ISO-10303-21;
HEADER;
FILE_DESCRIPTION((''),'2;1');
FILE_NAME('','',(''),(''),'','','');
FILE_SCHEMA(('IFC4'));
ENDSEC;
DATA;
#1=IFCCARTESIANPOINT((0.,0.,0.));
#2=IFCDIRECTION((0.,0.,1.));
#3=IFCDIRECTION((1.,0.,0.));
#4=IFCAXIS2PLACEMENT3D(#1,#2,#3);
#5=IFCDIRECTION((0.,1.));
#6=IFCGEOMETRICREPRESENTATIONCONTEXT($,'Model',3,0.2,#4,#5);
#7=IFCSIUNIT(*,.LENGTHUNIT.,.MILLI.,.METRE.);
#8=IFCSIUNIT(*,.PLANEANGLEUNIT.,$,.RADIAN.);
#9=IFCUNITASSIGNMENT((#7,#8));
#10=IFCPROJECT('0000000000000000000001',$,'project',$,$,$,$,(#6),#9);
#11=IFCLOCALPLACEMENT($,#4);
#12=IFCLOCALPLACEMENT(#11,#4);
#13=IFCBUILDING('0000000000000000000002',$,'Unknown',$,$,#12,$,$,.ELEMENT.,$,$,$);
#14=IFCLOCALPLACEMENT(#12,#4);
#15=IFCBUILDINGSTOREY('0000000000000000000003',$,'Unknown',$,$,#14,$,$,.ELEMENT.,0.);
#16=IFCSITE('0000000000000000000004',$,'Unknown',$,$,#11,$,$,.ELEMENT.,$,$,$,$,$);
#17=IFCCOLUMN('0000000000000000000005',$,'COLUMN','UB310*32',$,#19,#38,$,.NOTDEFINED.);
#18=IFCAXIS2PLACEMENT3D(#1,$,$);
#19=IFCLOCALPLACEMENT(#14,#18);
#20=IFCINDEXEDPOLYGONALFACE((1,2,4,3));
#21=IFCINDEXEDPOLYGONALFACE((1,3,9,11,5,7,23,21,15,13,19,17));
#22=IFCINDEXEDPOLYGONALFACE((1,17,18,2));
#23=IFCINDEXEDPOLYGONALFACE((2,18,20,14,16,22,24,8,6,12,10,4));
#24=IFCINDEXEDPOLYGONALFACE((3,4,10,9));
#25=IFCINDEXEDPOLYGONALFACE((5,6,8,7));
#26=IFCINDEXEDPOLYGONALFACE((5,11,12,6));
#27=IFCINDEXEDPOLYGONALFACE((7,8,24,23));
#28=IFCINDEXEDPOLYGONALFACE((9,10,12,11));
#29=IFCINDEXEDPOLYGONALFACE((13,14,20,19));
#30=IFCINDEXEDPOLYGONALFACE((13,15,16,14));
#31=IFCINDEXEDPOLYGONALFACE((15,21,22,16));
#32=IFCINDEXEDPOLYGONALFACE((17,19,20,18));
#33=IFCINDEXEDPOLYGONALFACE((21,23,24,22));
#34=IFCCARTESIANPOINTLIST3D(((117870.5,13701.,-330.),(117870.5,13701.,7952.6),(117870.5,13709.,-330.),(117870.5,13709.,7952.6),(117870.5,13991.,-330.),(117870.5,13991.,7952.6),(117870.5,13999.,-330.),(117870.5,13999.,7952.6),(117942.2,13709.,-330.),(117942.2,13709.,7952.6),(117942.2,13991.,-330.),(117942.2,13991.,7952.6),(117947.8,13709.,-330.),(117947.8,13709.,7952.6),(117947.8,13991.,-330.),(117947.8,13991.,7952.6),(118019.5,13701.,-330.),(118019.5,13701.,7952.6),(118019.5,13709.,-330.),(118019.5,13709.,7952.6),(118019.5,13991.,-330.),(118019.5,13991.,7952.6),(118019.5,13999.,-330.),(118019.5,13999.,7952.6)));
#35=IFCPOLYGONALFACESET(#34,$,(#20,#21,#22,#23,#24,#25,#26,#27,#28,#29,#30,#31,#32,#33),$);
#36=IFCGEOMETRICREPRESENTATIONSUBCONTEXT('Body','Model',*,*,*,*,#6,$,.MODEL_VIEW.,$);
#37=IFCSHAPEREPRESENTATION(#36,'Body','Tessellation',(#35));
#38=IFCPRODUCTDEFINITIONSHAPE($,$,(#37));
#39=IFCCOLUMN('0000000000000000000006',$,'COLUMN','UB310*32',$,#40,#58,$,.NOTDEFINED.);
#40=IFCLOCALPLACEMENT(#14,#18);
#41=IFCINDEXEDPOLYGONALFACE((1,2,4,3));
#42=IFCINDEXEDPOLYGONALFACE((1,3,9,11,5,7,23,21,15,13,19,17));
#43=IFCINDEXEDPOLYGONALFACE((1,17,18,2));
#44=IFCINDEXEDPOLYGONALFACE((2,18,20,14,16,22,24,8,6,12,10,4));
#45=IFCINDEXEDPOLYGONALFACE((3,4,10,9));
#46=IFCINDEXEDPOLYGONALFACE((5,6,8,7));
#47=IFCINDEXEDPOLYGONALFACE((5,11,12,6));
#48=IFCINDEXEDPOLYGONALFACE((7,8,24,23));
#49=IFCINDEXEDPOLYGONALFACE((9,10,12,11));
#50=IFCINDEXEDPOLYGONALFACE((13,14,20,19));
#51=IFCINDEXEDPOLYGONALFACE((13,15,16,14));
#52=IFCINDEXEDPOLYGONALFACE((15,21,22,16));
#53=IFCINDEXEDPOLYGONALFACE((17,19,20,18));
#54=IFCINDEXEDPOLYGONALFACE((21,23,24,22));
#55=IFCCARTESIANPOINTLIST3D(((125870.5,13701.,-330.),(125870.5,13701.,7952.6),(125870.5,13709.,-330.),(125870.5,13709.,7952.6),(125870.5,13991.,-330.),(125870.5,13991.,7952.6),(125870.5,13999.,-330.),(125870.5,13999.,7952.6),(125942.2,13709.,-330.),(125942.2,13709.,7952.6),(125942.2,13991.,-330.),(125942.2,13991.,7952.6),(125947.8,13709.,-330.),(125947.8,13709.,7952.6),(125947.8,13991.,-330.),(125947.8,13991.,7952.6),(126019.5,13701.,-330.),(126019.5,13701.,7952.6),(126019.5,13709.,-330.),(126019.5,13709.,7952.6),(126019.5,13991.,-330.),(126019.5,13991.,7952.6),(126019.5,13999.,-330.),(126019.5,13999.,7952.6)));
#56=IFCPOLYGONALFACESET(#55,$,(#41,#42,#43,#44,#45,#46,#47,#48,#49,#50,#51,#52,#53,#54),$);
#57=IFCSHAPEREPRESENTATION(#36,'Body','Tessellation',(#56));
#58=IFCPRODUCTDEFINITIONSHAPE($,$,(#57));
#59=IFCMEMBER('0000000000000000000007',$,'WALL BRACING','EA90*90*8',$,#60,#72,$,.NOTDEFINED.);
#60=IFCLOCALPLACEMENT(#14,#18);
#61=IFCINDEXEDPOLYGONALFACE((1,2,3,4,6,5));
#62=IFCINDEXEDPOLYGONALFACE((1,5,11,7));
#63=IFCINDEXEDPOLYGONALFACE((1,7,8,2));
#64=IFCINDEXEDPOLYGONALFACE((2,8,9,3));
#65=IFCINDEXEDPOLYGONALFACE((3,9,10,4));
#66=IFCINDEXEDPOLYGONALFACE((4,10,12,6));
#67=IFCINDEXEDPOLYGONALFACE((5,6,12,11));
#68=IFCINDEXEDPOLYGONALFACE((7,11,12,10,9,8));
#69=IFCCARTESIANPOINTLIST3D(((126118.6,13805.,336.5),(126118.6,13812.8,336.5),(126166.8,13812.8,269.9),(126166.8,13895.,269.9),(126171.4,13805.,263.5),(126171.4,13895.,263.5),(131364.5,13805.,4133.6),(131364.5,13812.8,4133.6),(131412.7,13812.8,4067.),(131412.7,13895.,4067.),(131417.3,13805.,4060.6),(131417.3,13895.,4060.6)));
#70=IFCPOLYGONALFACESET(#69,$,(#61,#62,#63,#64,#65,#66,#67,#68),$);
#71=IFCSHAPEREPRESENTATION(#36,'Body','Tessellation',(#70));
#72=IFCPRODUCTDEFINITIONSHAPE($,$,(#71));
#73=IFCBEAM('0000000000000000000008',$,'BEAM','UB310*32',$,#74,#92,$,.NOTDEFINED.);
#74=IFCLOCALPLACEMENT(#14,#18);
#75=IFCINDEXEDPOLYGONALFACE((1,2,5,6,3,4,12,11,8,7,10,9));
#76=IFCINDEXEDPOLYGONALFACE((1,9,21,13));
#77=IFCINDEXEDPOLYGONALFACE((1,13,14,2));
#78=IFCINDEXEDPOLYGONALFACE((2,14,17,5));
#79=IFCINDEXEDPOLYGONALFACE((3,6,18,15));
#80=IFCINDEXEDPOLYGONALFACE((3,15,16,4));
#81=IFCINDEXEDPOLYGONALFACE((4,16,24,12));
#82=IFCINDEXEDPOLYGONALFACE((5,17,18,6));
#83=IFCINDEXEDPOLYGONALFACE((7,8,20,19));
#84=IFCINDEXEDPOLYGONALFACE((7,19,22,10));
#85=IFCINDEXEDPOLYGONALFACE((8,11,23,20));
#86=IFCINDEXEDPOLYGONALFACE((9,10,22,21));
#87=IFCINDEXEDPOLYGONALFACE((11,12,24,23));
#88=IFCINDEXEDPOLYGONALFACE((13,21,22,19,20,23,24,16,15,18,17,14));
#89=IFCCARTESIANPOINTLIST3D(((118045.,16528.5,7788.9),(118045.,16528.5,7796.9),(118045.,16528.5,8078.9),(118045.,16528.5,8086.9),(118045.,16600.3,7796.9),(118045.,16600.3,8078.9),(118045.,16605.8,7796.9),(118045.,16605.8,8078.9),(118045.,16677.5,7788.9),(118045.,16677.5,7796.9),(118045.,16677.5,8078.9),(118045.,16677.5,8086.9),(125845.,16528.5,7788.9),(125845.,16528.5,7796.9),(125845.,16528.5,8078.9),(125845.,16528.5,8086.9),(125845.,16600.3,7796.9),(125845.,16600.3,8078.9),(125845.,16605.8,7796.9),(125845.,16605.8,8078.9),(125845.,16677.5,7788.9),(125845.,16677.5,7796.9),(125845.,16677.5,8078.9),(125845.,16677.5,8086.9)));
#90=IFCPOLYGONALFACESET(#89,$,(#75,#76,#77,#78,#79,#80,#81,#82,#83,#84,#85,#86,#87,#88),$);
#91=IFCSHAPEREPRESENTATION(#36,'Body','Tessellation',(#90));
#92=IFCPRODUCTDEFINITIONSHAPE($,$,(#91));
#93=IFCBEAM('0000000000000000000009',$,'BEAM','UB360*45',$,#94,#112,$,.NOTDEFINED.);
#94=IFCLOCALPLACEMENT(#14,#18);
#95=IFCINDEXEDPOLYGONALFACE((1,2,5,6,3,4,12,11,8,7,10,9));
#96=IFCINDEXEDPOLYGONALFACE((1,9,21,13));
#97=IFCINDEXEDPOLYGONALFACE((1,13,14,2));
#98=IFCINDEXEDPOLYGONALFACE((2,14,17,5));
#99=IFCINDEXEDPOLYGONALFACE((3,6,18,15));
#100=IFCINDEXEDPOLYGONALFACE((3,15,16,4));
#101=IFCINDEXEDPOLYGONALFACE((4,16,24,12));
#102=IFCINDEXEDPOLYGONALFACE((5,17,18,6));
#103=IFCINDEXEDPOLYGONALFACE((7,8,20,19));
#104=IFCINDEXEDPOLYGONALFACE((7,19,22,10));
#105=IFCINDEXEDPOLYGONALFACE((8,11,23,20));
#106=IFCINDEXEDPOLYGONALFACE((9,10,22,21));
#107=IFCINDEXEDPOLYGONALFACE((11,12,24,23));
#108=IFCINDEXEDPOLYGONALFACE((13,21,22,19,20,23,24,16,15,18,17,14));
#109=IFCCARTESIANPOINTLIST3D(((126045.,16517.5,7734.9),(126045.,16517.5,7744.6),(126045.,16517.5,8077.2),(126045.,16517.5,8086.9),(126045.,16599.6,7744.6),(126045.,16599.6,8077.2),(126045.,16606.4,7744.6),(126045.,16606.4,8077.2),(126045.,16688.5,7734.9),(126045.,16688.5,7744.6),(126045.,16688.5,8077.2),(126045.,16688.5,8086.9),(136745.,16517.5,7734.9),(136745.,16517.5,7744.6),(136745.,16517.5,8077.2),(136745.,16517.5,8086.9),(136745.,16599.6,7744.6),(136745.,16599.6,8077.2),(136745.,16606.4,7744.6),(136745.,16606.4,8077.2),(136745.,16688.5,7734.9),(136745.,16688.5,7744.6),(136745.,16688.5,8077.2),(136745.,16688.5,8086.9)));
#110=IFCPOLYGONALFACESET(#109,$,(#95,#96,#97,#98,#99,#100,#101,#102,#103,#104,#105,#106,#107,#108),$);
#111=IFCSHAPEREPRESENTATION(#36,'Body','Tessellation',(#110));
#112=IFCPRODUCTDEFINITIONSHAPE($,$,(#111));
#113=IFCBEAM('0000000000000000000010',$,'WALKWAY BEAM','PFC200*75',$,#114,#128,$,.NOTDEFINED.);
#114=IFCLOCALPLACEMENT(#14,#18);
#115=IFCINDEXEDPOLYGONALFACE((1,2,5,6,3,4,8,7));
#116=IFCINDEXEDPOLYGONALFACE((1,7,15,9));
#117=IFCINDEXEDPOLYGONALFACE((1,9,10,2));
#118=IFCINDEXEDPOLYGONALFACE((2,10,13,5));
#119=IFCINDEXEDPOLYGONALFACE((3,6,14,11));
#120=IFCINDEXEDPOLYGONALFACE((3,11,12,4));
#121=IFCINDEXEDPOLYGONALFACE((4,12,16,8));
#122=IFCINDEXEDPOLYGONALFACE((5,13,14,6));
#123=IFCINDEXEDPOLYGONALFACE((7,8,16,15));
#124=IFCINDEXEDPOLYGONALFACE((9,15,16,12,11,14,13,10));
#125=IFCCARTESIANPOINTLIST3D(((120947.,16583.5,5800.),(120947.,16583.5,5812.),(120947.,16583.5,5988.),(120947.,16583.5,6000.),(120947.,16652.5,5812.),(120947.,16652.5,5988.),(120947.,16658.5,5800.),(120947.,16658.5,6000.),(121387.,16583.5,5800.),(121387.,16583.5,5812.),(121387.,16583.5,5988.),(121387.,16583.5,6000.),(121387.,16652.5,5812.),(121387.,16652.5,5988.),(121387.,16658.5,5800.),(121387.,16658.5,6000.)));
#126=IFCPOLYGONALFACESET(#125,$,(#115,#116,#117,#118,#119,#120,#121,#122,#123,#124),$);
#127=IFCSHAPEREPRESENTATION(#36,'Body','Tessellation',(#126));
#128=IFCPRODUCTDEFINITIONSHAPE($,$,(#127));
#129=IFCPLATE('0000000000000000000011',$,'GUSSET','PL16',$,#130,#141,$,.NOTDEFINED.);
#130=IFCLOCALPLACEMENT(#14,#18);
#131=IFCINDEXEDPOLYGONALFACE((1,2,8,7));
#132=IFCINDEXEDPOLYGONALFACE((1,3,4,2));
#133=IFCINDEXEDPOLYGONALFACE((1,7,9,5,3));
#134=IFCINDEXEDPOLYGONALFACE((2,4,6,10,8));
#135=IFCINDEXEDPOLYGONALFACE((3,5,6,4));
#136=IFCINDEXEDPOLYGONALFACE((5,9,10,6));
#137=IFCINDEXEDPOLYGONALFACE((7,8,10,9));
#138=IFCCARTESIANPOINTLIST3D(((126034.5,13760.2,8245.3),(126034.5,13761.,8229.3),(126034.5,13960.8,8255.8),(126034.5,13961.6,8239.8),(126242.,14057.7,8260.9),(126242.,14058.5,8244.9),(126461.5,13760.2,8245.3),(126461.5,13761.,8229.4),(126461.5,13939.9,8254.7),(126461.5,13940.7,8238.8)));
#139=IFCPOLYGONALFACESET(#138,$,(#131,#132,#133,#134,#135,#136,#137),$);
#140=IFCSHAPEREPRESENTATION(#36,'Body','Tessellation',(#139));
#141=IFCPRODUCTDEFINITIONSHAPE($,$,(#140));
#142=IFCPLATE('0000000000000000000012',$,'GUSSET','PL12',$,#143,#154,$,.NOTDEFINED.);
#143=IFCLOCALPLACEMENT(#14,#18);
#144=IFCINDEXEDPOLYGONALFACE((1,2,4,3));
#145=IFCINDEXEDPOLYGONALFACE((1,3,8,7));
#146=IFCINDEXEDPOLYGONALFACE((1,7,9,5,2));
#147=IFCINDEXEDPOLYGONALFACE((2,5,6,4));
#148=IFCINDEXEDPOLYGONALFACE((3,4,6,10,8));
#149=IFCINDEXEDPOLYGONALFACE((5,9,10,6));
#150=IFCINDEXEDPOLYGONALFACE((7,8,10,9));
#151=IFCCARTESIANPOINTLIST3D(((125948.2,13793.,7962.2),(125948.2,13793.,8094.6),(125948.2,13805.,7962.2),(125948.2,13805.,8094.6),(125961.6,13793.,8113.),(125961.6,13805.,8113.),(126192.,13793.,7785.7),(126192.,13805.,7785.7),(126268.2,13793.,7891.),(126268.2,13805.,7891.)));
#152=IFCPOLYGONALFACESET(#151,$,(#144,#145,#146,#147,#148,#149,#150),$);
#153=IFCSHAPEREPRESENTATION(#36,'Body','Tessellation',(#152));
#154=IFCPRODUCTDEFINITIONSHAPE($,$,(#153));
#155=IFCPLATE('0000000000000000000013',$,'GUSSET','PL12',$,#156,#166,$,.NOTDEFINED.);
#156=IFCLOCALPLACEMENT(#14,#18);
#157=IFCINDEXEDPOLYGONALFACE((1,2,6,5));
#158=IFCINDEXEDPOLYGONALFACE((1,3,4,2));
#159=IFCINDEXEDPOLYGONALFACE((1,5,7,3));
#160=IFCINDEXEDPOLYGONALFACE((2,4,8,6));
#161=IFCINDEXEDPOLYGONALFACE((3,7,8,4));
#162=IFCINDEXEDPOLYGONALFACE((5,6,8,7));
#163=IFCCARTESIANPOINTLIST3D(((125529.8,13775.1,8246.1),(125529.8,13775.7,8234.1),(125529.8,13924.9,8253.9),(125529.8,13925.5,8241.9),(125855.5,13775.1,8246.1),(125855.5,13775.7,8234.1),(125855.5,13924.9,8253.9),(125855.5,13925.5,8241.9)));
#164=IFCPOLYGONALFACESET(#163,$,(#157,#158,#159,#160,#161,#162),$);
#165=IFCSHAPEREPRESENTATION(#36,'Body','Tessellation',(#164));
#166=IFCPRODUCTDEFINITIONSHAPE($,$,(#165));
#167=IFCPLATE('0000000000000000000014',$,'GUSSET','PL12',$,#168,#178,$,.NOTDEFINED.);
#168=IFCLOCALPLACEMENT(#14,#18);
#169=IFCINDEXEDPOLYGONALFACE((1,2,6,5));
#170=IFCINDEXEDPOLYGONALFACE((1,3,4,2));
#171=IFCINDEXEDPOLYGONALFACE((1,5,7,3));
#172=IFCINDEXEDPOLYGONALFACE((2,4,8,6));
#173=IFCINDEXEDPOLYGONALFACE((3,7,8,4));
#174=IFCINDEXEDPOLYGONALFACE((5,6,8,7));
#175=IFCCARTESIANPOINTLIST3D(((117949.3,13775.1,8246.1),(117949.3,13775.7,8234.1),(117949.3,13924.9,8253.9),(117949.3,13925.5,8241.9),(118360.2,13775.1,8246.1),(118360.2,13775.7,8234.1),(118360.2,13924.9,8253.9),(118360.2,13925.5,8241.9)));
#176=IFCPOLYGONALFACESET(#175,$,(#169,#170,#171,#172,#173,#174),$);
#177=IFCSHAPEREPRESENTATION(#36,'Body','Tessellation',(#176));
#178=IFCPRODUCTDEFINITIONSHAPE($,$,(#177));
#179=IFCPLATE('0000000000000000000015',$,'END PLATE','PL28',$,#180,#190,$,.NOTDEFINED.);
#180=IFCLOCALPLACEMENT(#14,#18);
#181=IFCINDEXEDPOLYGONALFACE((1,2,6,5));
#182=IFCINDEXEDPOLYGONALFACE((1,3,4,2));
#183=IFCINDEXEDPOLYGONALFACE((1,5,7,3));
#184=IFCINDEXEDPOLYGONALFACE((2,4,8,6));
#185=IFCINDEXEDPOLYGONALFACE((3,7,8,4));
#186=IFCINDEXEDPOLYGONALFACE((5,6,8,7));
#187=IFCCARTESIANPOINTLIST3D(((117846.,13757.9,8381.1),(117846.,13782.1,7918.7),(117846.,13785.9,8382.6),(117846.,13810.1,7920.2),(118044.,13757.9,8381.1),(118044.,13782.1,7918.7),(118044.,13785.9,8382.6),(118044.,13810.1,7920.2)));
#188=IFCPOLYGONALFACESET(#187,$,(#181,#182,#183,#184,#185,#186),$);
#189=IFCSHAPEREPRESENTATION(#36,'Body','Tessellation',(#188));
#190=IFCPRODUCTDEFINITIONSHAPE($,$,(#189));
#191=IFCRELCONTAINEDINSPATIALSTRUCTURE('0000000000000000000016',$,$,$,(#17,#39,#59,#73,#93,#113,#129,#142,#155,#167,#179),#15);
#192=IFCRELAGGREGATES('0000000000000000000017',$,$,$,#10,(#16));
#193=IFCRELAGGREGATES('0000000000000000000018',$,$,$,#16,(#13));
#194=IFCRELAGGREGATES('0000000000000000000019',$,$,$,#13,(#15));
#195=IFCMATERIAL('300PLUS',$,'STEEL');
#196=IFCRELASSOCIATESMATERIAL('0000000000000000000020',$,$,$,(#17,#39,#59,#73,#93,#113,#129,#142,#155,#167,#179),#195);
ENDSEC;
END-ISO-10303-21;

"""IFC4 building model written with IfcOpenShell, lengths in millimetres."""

from ifc_helpers import new_model, si_unit, direction, frame, origin_with_axes, place, context, subcontext, project, spatial, line, indexed_curve, outline, extrude, material, element, save


model = new_model("IFC4")

# Units and contexts
model_context = context("Model", 3, precision=0.2, world=origin_with_axes(), true_north=direction((0.0, 1.0)))
body_context = subcontext(model_context, "Body", "Model", "MODEL_VIEW")
ifc_project = project(units=[si_unit("LENGTHUNIT", "METRE", prefix="MILLI"), si_unit("PLANEANGLEUNIT", "RADIAN")], contexts=[model_context])

# Site, building, storey
site_placement = place(None, origin_with_axes())
site = spatial("IfcSite", under=ifc_project, at=site_placement, Name="Unknown", CompositionType="ELEMENT")
building_placement = place(site_placement, origin_with_axes())
building = spatial("IfcBuilding", under=site, at=building_placement, Name="Unknown", CompositionType="ELEMENT")
storey_placement = place(building_placement, origin_with_axes())
storey = spatial("IfcBuildingStorey", under=building, at=storey_placement, Name="Unknown", CompositionType="ELEMENT", Elevation=0.0)

# Columns
ifc_material_1 = material(Name="300PLUS", Category="STEEL")
for number, where, z_axis, x_axis, name in (
    (1, (117945.0, 13850.0, -330.0), (-1.0, 0.0, 0.0), (0.0, 0.0, 1.0), "COLUMN"),
    (2, (125945.0, 13850.0, -330.0), (-1.0, 0.0, 0.0), (0.0, 0.0, 1.0), "COLUMN"),
):
    element("IfcColumn", number, at=place(storey_placement, frame(where, z_axis=z_axis, x_axis=x_axis)), inside=storey, material=ifc_material_1, Name=name, Description="UB310*32", PredefinedType="NOTDEFINED", context=body_context, shape_type="SolidModel", body=[
        extrude(outline(indexed_curve([(-74.5, -149.0), (74.5, -149.0), (74.5, -141.0), (2.8, -141.0), (2.8, 141.0), (74.5, 141.0), (74.5, 149.0), (-74.5, 149.0), (-74.5, 141.0), (-2.8, 141.0), (-2.8, -141.0), (-74.5, -141.0)], segments=[line(1, 2, 3, 4, 5, 6, 7, 8, 9, 10, 11, 12, 1)])), frame((0.0, 0.0, 0.0), z_axis=(-1.0, 0.0, 0.0), x_axis=(0.0, 0.0, 1.0)), (0.0, 0.0, -1.0), 8282.6),
    ])

# Member
member_placement = place(storey_placement, frame((126145.0, 13850.0, 300.0), z_axis=(-0.586342, 0.0, 0.810064), x_axis=(0.810064, 0.0, 0.586342)))
element("IfcMember", 3, at=member_placement, inside=storey, material=ifc_material_1, Name="WALL BRACING", Description="EA90*90*8", PredefinedType="NOTDEFINED", context=body_context, shape_type="SolidModel", body=[
    extrude(outline(indexed_curve([(-45.0, -45.0), (45.0, -45.0), (45.0, -37.2), (-37.2, -37.2), (-37.2, 45.0), (-45.0, 45.0)], segments=[line(1, 2, 3, 4, 5, 6, 1)])), frame((0.0, 0.0, 0.0), z_axis=(-1.0, 0.0, 0.0), x_axis=(0.0, 0.0, 1.0)), (0.0, 0.0, -1.0), 6475.9),
])

# Beams
beam_1_placement = place(storey_placement, frame((118045.0, 16603.0, 7937.9), z_axis=(0.0, -1.0, 0.0), x_axis=(1.0, 0.0, 0.0)))
element("IfcBeam", 4, at=beam_1_placement, inside=storey, material=ifc_material_1, Name="BEAM", Description="UB310*32", PredefinedType="NOTDEFINED", context=body_context, shape_type="SolidModel", body=[
    extrude(outline(indexed_curve([(-74.5, -149.0), (74.5, -149.0), (74.5, -141.0), (2.8, -141.0), (2.8, 141.0), (74.5, 141.0), (74.5, 149.0), (-74.5, 149.0), (-74.5, 141.0), (-2.8, 141.0), (-2.8, -141.0), (-74.5, -141.0)], segments=[line(1, 2, 3, 4, 5, 6, 7, 8, 9, 10, 11, 12, 1)])), frame((0.0, 0.0, 0.0), z_axis=(-1.0, 0.0, 0.0), x_axis=(0.0, 0.0, 1.0)), (0.0, 0.0, -1.0), 7800.0),
])
beam_2_placement = place(storey_placement, frame((126045.0, 16603.0, 7910.9), z_axis=(0.0, -1.0, 0.0), x_axis=(1.0, 0.0, 0.0)))
element("IfcBeam", 5, at=beam_2_placement, inside=storey, material=ifc_material_1, Name="BEAM", Description="UB360*45", PredefinedType="NOTDEFINED", context=body_context, shape_type="SolidModel", body=[
    extrude(outline(indexed_curve([(-85.5, -176.0), (85.5, -176.0), (85.5, -166.3), (3.5, -166.3), (3.5, 166.3), (85.5, 166.3), (85.5, 176.0), (-85.5, 176.0), (-85.5, 166.3), (-3.5, 166.3), (-3.5, -166.3), (-85.5, -166.3)], segments=[line(1, 2, 3, 4, 5, 6, 7, 8, 9, 10, 11, 12, 1)])), frame((0.0, 0.0, 0.0), z_axis=(-1.0, 0.0, 0.0), x_axis=(0.0, 0.0, 1.0)), (0.0, 0.0, -1.0), 10700.0),
])
beam_3_placement = place(storey_placement, frame((120947.0, 16621.0, 5900.0), z_axis=(0.0, -1.0, 0.0), x_axis=(1.0, 0.0, 0.0)))
element("IfcBeam", 6, at=beam_3_placement, inside=storey, material=ifc_material_1, Name="WALKWAY BEAM", Description="PFC200*75", PredefinedType="NOTDEFINED", context=body_context, shape_type="SolidModel", body=[
    extrude(outline(indexed_curve([(-37.5, -100.0), (37.5, -100.0), (37.5, -88.0), (-31.5, -88.0), (-31.5, 88.0), (37.5, 88.0), (37.5, 100.0), (-37.5, 100.0)], segments=[line(1, 2, 3, 4, 5, 6, 7, 8, 1)])), frame((0.0, 0.0, 0.0), z_axis=(-1.0, 0.0, 0.0), x_axis=(0.0, 0.0, 1.0)), (0.0, 0.0, -1.0), 440.0),
])

# Plates
plate_1_placement = place(storey_placement, frame((126034.5, 13961.2, 8247.8), z_axis=(-0.000135, -0.052271, 0.998633), x_axis=(0.0, -0.998633, -0.052271)))
element("IfcPlate", 7, at=plate_1_placement, inside=storey, material=ifc_material_1, Name="GUSSET", Description="PL16", PredefinedType="NOTDEFINED", context=body_context, shape_type="SolidModel", body=[
    extrude(outline(indexed_curve([(0.0, 0.0), (200.9, 0.0), (200.9, 427.0), (20.9, 427.0), (-97.0, 207.5)], segments=[line(1, 2, 3, 4, 5, 1)])), frame((0.0, 0.0, 8.0), z_axis=(0.0, 0.0, 1.0), x_axis=(1.0, 0.0, 0.0)), (0.0, 0.0, -1.0), 16.0),
])
plate_2_placement = place(storey_placement, frame((125948.2, 13799.0, 8094.6), z_axis=(0.0, -1.0, 0.0), x_axis=(0.0, 0.0, -1.0)))
element("IfcPlate", 8, at=plate_2_placement, inside=storey, material=ifc_material_1, Name="GUSSET", Description="PL12", PredefinedType="NOTDEFINED", context=body_context, shape_type="SolidModel", body=[
    extrude(outline(indexed_curve([(0.0, 0.0), (132.4, 0.0), (308.9, 243.8), (203.6, 320.0), (-18.4, 13.4)], segments=[line(1, 2, 3, 4, 5, 1)])), frame((0.0, 0.0, 6.0), z_axis=(0.0, 0.0, 1.0), x_axis=(1.0, 0.0, 0.0)), (0.0, 0.0, -1.0), 12.0),
])
plate_3_placement = place(storey_placement, frame((125855.5, 13925.2, 8247.9), z_axis=(0.0, -0.051999, 0.998647), x_axis=(-1.0, 0.0, 0.0)))
element("IfcPlate", 9, at=plate_3_placement, inside=storey, material=ifc_material_1, Name="GUSSET", Description="PL12", PredefinedType="NOTDEFINED", context=body_context, shape_type="SolidModel", body=[
    extrude(outline(indexed_curve([(0.0, 0.0), (325.7, 0.0), (325.7, 150.0), (0.0, 150.0)], segments=[line(1, 2, 3, 4, 1)])), frame((0.0, 0.0, 6.0), z_axis=(0.0, 0.0, 1.0), x_axis=(1.0, 0.0, 0.0)), (0.0, 0.0, -1.0), 12.0),
])
plate_4_placement = place(storey_placement, frame((117949.3, 13775.4, 8240.1), z_axis=(0.0, -0.051999, 0.998647), x_axis=(1.0, 0.0, 0.0)))
element("IfcPlate", 10, at=plate_4_placement, inside=storey, material=ifc_material_1, Name="GUSSET", Description="PL12", PredefinedType="NOTDEFINED", context=body_context, shape_type="SolidModel", body=[
    extrude(outline(indexed_curve([(0.0, 0.0), (410.9, 0.0), (410.9, 150.0), (0.0, 150.0)], segments=[line(1, 2, 3, 4, 1)])), frame((0.0, 0.0, 6.0), z_axis=(0.0, 0.0, 1.0), x_axis=(1.0, 0.0, 0.0)), (0.0, 0.0, -1.0), 12.0),
])
plate_5_placement = place(storey_placement, frame((118044.0, 13796.1, 7919.4), z_axis=(0.0, 0.998633, 0.052264), x_axis=(-1.0, 0.0, 0.0)))
element("IfcPlate", 11, at=plate_5_placement, inside=storey, material=ifc_material_1, Name="END PLATE", Description="PL28", PredefinedType="NOTDEFINED", context=body_context, shape_type="SolidModel", body=[
    extrude(outline(indexed_curve([(0.0, 0.0), (198.0, 0.0), (198.0, 463.0), (0.0, 463.0)], segments=[line(1, 2, 3, 4, 1)])), frame((0.0, 0.0, 14.0), z_axis=(0.0, 0.0, 1.0), x_axis=(1.0, 0.0, 0.0)), (0.0, 0.0, -1.0), 28.0),
])

save(model, "model.ifc")
